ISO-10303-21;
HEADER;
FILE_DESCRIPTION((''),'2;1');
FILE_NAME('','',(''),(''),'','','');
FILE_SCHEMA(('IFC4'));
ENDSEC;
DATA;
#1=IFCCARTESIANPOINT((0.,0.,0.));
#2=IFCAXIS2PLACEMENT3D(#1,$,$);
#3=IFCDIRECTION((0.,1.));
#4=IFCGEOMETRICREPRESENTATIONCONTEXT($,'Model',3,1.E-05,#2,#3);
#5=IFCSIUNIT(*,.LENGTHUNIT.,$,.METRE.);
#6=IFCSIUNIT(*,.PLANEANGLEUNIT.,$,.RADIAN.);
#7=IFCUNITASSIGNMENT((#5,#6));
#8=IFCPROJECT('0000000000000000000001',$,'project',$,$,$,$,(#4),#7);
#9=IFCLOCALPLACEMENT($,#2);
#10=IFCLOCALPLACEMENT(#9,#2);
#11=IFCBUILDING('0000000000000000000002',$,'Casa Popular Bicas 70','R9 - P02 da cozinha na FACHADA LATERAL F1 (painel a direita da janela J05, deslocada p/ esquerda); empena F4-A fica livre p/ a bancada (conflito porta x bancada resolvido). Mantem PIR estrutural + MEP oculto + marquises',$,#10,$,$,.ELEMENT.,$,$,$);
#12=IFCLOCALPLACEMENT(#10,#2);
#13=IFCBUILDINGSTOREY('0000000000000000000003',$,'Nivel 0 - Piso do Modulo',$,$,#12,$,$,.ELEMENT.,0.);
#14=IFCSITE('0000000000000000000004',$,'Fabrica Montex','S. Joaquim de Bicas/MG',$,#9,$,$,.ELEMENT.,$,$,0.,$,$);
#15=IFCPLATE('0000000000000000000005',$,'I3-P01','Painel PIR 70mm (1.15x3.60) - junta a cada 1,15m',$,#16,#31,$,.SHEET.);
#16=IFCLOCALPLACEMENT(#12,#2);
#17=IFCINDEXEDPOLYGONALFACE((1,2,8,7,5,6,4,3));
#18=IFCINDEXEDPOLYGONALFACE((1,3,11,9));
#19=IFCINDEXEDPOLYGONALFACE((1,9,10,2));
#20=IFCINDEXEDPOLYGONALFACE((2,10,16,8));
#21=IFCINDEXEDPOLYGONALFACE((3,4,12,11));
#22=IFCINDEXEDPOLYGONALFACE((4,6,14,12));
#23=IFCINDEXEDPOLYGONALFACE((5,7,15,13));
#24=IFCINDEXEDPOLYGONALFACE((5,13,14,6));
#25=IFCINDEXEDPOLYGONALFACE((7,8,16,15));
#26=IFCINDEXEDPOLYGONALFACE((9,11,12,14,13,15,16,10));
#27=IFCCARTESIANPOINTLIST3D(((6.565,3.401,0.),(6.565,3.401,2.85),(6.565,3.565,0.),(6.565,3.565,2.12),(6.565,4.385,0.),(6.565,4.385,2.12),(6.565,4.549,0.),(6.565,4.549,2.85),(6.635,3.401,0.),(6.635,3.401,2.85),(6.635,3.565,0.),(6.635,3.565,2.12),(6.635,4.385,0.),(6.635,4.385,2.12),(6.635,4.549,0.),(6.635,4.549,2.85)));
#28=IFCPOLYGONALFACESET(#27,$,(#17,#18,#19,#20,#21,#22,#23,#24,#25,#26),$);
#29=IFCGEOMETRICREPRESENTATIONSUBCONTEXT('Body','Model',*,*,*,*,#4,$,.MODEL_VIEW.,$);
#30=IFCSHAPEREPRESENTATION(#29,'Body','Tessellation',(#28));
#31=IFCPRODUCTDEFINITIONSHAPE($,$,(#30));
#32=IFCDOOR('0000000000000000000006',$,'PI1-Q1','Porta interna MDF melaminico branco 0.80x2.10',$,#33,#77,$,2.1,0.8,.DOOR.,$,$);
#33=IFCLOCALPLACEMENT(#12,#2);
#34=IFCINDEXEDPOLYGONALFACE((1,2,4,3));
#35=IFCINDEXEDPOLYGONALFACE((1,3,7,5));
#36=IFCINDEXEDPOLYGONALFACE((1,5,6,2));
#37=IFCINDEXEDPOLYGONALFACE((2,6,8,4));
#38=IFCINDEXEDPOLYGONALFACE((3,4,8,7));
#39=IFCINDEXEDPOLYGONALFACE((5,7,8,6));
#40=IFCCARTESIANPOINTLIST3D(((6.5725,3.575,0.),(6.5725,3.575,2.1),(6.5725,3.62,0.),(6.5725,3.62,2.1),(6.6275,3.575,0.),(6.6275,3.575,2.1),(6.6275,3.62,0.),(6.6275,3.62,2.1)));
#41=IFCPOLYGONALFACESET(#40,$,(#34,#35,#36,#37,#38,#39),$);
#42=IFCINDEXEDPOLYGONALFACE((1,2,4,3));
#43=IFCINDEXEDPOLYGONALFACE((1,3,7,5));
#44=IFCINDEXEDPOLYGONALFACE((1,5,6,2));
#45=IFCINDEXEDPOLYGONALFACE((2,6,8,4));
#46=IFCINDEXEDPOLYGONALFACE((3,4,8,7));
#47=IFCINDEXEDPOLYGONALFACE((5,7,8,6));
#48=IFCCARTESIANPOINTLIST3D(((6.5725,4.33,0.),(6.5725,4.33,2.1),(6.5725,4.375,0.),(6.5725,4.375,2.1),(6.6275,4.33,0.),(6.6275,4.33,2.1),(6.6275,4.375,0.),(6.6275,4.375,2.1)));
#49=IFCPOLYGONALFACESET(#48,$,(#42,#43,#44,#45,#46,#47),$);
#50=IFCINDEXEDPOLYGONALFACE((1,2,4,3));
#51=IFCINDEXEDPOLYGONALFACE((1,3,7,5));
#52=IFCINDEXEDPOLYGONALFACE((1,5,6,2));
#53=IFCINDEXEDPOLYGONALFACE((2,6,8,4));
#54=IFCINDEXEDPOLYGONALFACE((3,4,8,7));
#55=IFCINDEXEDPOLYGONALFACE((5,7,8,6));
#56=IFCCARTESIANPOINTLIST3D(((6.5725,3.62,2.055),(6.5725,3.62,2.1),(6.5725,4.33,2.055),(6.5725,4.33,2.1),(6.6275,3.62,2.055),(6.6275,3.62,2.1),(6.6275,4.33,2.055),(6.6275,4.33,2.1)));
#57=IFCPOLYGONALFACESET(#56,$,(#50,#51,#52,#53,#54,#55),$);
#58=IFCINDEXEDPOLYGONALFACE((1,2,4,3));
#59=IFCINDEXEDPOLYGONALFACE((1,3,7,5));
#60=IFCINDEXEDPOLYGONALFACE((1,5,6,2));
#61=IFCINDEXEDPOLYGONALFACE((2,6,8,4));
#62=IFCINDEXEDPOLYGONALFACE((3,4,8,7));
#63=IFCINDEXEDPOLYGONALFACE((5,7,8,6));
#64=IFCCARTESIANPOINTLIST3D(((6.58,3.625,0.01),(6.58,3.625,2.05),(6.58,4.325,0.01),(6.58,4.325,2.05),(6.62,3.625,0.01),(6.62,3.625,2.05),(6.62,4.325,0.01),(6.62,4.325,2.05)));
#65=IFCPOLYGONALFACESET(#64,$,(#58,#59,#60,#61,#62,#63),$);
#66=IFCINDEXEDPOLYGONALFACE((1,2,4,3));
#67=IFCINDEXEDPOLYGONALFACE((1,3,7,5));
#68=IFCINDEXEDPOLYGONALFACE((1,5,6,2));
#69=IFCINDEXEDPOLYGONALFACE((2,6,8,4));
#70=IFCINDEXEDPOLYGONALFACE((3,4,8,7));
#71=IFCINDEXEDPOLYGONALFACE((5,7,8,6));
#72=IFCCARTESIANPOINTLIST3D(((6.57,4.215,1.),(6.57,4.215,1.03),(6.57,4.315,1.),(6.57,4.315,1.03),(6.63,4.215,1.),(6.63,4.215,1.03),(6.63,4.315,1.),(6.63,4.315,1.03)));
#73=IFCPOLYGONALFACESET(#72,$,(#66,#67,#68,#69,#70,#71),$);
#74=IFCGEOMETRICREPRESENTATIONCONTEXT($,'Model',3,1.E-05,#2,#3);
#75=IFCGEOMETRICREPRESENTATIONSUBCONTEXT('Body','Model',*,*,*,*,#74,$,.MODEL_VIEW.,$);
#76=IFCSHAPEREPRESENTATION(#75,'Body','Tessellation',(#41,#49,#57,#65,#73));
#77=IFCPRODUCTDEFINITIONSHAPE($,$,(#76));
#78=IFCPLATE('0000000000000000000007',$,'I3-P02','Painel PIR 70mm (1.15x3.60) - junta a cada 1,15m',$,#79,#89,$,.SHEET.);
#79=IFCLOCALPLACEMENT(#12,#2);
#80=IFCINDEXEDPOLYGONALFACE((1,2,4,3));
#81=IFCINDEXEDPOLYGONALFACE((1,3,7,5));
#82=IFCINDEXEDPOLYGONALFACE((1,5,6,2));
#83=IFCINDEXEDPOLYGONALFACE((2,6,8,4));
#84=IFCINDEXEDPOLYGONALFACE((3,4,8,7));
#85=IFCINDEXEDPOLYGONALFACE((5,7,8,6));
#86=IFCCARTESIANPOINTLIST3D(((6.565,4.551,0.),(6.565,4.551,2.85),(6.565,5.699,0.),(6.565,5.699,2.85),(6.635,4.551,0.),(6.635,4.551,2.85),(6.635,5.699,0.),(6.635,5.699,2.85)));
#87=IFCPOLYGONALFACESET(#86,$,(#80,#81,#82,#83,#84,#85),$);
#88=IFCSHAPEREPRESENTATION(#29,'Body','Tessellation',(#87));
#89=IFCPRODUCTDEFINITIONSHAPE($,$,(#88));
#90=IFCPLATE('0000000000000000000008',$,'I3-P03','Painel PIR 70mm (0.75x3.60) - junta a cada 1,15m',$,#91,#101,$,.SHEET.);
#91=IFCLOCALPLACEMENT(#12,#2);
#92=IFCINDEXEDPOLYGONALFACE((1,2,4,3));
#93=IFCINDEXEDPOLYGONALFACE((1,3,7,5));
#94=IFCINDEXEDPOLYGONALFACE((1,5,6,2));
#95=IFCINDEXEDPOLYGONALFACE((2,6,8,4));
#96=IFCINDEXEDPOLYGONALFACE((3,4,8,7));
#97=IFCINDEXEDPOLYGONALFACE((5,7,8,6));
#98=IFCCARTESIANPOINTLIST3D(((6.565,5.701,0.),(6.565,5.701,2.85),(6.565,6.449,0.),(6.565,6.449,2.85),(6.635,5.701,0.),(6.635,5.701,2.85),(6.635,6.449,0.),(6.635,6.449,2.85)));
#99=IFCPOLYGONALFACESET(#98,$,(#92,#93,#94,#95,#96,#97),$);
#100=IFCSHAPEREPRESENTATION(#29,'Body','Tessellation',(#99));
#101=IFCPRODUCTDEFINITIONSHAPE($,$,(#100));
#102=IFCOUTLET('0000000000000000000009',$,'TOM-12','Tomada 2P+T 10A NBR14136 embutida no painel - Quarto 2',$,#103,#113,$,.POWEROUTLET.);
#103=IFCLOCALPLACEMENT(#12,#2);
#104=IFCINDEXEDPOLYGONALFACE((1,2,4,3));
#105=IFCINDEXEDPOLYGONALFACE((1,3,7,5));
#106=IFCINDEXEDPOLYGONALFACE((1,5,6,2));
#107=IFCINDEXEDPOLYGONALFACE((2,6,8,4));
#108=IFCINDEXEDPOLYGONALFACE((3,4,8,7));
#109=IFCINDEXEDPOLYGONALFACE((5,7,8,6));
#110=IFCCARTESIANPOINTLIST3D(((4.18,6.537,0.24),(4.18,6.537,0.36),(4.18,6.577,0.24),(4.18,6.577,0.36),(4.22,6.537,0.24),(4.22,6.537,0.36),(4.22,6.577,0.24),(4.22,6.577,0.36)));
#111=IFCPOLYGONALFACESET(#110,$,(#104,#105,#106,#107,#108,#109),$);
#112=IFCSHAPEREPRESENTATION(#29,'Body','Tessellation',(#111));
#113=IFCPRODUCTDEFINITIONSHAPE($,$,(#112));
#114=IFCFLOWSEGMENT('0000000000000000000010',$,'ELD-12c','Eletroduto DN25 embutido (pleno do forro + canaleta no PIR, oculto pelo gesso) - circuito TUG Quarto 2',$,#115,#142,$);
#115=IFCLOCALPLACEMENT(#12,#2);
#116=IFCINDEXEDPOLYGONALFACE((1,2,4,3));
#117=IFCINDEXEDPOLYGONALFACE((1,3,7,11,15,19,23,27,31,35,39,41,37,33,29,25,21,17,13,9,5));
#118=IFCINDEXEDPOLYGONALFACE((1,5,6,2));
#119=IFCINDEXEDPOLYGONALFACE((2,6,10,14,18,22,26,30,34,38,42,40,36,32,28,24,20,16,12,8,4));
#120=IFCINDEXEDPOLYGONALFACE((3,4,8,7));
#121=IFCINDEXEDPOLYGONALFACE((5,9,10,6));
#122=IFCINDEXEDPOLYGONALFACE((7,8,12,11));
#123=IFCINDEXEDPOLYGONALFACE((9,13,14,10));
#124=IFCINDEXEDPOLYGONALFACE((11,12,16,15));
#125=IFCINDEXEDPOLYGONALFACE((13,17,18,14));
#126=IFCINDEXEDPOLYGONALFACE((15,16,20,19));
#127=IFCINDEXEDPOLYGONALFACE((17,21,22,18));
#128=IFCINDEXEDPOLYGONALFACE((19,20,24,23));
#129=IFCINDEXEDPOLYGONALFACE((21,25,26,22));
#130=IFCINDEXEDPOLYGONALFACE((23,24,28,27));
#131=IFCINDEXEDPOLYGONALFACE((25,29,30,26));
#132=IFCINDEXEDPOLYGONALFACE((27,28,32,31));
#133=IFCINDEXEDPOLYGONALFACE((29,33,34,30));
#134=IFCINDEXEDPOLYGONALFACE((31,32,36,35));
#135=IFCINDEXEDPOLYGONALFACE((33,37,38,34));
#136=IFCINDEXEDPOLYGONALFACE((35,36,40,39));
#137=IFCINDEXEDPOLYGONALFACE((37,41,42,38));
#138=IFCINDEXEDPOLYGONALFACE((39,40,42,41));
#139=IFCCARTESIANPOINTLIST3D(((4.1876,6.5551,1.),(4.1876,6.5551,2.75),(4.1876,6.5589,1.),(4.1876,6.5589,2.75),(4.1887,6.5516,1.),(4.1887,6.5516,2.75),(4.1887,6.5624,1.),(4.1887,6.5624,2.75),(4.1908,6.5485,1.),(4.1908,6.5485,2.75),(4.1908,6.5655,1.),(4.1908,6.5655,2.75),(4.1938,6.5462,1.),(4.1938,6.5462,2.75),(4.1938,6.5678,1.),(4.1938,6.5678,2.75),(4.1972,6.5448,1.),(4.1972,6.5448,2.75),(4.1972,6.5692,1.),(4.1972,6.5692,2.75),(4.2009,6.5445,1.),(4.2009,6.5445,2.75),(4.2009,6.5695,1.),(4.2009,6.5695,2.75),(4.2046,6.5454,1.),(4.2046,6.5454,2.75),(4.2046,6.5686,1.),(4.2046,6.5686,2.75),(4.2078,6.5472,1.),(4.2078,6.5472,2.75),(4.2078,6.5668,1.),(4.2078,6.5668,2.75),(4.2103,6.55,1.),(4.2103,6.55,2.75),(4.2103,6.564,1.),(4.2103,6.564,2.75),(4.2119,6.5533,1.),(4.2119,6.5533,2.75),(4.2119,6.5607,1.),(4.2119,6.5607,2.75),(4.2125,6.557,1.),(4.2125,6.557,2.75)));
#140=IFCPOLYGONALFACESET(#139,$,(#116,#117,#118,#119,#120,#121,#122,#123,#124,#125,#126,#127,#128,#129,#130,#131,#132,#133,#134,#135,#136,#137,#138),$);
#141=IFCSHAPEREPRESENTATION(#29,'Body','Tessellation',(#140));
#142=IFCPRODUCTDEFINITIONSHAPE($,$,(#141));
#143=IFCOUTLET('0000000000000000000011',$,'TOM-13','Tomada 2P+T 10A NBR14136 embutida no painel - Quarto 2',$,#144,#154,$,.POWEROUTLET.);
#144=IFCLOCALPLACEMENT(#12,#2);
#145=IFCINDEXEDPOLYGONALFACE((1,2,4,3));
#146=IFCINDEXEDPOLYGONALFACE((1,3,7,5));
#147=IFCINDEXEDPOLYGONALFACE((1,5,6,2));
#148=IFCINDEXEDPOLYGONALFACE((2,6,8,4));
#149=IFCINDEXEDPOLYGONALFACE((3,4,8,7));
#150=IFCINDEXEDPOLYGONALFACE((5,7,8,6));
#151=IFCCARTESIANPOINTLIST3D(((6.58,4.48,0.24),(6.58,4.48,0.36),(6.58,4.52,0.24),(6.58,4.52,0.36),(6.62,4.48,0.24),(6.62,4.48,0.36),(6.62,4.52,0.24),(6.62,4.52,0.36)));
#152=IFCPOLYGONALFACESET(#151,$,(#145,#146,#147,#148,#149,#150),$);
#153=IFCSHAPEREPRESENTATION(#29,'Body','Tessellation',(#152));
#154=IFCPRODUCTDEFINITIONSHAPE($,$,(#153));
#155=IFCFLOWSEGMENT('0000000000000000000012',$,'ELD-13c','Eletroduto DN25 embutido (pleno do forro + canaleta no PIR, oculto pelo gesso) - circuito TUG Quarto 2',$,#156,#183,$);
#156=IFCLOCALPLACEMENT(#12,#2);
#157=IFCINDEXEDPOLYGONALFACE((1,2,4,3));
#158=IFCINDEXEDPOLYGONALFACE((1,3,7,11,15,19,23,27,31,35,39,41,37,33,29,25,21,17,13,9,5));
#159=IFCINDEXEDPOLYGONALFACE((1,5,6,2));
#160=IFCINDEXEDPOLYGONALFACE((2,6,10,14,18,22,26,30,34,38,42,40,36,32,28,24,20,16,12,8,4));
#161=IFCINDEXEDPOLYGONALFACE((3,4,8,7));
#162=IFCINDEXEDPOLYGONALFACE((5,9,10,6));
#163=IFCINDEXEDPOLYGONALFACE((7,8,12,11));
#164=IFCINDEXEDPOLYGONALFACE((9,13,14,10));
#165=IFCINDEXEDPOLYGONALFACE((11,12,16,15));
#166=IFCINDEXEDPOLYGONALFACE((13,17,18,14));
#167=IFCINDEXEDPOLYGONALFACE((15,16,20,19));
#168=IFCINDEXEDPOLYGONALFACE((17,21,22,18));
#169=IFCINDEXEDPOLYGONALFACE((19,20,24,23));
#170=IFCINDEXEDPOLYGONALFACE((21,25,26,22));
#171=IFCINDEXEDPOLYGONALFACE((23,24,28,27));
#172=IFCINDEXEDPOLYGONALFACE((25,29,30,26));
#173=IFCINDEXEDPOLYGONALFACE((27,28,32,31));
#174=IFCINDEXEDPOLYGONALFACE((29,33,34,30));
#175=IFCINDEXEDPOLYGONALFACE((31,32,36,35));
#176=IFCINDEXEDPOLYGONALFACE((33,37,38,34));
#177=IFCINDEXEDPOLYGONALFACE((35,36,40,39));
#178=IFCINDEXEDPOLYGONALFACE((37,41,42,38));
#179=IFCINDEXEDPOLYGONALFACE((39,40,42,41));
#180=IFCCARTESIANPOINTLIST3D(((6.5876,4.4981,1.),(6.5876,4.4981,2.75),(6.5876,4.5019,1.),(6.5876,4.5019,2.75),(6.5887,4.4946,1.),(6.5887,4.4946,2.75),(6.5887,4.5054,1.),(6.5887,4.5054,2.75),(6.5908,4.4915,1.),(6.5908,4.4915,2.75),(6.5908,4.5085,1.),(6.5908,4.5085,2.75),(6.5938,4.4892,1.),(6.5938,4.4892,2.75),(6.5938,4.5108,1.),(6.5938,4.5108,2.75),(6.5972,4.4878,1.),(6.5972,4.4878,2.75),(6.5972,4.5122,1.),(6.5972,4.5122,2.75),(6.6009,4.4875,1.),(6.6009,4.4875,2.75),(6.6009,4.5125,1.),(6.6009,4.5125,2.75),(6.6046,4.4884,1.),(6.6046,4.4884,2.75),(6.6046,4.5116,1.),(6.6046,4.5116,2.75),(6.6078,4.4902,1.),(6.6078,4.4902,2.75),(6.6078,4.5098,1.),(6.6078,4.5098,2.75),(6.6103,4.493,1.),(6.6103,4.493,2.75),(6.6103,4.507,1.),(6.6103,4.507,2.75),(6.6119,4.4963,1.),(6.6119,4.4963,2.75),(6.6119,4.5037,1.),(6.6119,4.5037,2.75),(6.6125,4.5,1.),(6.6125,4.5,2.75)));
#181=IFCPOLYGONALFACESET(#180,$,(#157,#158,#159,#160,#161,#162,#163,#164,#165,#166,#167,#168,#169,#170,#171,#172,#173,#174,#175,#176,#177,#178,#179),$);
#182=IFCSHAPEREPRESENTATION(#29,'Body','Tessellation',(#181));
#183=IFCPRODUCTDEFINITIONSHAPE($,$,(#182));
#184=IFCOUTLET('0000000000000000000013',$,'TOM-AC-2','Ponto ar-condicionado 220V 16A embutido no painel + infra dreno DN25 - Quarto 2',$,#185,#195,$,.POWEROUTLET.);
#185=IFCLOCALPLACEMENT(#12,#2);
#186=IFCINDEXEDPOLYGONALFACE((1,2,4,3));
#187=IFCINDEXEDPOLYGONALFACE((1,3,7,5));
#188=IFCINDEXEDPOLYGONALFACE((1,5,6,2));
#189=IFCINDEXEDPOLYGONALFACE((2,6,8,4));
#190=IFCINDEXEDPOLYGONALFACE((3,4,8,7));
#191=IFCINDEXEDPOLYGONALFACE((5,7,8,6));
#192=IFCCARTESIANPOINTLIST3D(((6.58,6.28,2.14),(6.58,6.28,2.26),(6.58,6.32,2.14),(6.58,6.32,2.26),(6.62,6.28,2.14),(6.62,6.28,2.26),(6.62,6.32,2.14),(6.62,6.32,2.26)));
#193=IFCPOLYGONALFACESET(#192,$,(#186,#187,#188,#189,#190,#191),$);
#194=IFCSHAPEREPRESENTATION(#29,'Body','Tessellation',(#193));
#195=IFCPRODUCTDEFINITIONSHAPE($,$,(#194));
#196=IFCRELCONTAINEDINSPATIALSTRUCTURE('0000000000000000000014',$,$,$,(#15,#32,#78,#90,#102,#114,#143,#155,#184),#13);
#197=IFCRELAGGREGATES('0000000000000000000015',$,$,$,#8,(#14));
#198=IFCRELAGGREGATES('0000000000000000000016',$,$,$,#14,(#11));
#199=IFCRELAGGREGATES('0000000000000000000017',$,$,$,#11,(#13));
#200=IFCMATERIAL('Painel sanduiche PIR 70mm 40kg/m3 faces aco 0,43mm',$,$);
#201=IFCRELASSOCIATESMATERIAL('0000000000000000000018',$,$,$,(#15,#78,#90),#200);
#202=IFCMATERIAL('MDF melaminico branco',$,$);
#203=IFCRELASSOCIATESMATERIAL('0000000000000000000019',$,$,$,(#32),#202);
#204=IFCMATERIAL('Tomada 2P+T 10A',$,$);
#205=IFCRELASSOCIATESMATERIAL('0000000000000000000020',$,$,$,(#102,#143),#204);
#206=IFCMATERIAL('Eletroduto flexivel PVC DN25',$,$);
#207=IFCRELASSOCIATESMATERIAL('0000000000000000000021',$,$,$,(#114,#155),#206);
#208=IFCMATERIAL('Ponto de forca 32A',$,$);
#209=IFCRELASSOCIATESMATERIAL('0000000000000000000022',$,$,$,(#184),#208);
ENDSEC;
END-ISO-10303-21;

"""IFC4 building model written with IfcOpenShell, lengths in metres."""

from ifc_helpers import new_model, si_unit, direction, frame, frame_2d, origin, origin_2d, place, context, subcontext, project, spatial, rectangle, circle, extrude, material, element, fill, save


model = new_model("IFC4")

# Units and contexts
model_context_1 = context("Model", 3, precision=1e-05, world=origin(), true_north=direction((0.0, 1.0)))
model_context_2 = context("Model", 3, precision=1e-05, world=origin(), true_north=direction((0.0, 1.0)))
model_context_3 = context("Model", 3, precision=1e-05, world=origin(), true_north=direction((0.0, 1.0)))
body_context_1 = subcontext(model_context_1, "Body", "Model", "MODEL_VIEW")
body_context_2 = subcontext(model_context_2, "Body", "Model", "MODEL_VIEW")
body_context_3 = subcontext(model_context_3, "Body", "Model", "MODEL_VIEW")
ifc_project = project(units=[si_unit("LENGTHUNIT", "METRE"), si_unit("PLANEANGLEUNIT", "RADIAN")], contexts=[model_context_1])

# Site, building, storey
site_placement = place(None, origin())
site = spatial("IfcSite", under=ifc_project, at=site_placement, Name="Fabrica Montex", Description="S. Joaquim de Bicas/MG", CompositionType="ELEMENT", RefElevation=0.0)
building_placement = place(site_placement, origin())
building = spatial("IfcBuilding", under=site, at=building_placement, Name="Casa Popular Bicas 70", Description="R9 - P02 da cozinha na FACHADA LATERAL F1 (painel a direita da janela J05, deslocada p/ esquerda); empena F4-A fica livre p/ a bancada (conflito porta x bancada resolvido). Mantem PIR estrutural + MEP oculto + marquises", CompositionType="ELEMENT")
storey_placement = place(building_placement, origin())
storey = spatial("IfcBuildingStorey", under=building, at=storey_placement, Name="Nivel 0 - Piso do Modulo", CompositionType="ELEMENT", Elevation=0.0)

# Shared definitions
ifc_material_1 = material(Name="Painel sanduiche PIR 70mm 40kg/m3 faces aco 0,43mm")

# Plate, opening, door
plate_1_placement = place(storey_placement, frame((6.6, 3.401, 0.0), x_axis=(0.0, 1.0, 0.0)))
plate_1 = element("IfcPlate", 1, at=plate_1_placement, inside=storey, material=ifc_material_1, Name="I3-P01", Description="Painel PIR 70mm (1.15x3.60) - junta a cada 1,15m", PredefinedType="SHEET", context=body_context_1, shape_type="SweptSolid", body=[
    extrude(rectangle(XDim=1.148, YDim=0.07, at=frame_2d((0.574, 0.0))), origin(), (0.0, 0.0, 1.0), 2.85),
])
placement_1 = place(None, origin())
placement_2 = place(placement_1, origin())
placement_3 = place(placement_2, origin())
opening_1_placement = place(placement_3, frame((6.6, 3.575, 0.0), x_axis=(0.0, 1.0, 0.0)))
opening_1 = element("IfcOpeningElement", 2, at=opening_1_placement, cuts=plate_1, PredefinedType="OPENING", context=body_context_3, shape_type="SweptSolid", body=[
    extrude(rectangle(XDim=0.82, YDim=0.3, at=frame_2d((0.4, 0.0))), origin(), (0.0, 0.0, 1.0), 2.12),
])
ifc_material_2 = material(Name="MDF melaminico branco")
placement_4 = place(None, origin())
placement_5 = place(placement_4, origin())
placement_6 = place(placement_5, origin())
door_placement = place(placement_6, frame((6.6, 3.575, 0.0), x_axis=(0.0, 1.0, 0.0)))
door = element("IfcDoor", 3, at=door_placement, inside=storey, material=ifc_material_2, Name="PI1-Q1", Description="Porta interna MDF melaminico branco 0.80x2.10", OverallHeight=2.1, OverallWidth=0.8, PredefinedType="DOOR", context=body_context_2, shape_type="SweptSolid", body=[
    extrude(rectangle(XDim=0.045, YDim=0.055, at=frame_2d((0.0225, 0.0))), origin(), (0.0, 0.0, 1.0), 2.1),
    extrude(rectangle(XDim=0.045, YDim=0.055, at=frame_2d((0.7775, 0.0))), origin(), (0.0, 0.0, 1.0), 2.1),
    extrude(rectangle(XDim=0.71, YDim=0.055, at=frame_2d((0.4, 0.0))), frame((0.0, 0.0, 2.055)), (0.0, 0.0, 1.0), 0.045),
    extrude(rectangle(XDim=0.7, YDim=0.04, at=frame_2d((0.4, 0.0))), frame((0.0, 0.0, 0.01)), (0.0, 0.0, 1.0), 2.04),
    extrude(rectangle(XDim=0.1, YDim=0.06, at=frame_2d((0.69, 0.0))), frame((0.0, 0.0, 1.0)), (0.0, 0.0, 1.0), 0.03),
])
fill(opening_1, door)

# Plates
plate_2_placement = place(storey_placement, frame((6.6, 4.551, 0.0), x_axis=(0.0, 1.0, 0.0)))
element("IfcPlate", 4, at=plate_2_placement, inside=storey, material=ifc_material_1, Name="I3-P02", Description="Painel PIR 70mm (1.15x3.60) - junta a cada 1,15m", PredefinedType="SHEET", context=body_context_1, shape_type="SweptSolid", body=[
    extrude(rectangle(XDim=1.148, YDim=0.07, at=frame_2d((0.574, 0.0))), origin(), (0.0, 0.0, 1.0), 2.85),
])
plate_3_placement = place(storey_placement, frame((6.6, 5.701, 0.0), x_axis=(0.0, 1.0, 0.0)))
element("IfcPlate", 5, at=plate_3_placement, inside=storey, material=ifc_material_1, Name="I3-P03", Description="Painel PIR 70mm (0.75x3.60) - junta a cada 1,15m", PredefinedType="SHEET", context=body_context_1, shape_type="SweptSolid", body=[
    extrude(rectangle(XDim=0.748, YDim=0.07, at=frame_2d((0.374, 0.0))), origin(), (0.0, 0.0, 1.0), 2.85),
])

# Outlet
ifc_material_3 = material(Name="Tomada 2P+T 10A")
outlet_1_placement = place(storey_placement, frame((4.18, 6.537, 0.24)))
element("IfcOutlet", 6, at=outlet_1_placement, inside=storey, material=ifc_material_3, Name="TOM-12", Description="Tomada 2P+T 10A NBR14136 embutida no painel - Quarto 2", PredefinedType="POWEROUTLET", context=body_context_1, shape_type="SweptSolid", body=[
    extrude(rectangle(XDim=0.04, YDim=0.04, at=frame_2d((0.02, 0.02))), origin(), (0.0, 0.0, 1.0), 0.12),
])

# Flow segment
ifc_material_4 = material(Name="Eletroduto flexivel PVC DN25")
flow_segment_1_placement = place(storey_placement, frame((4.2, 6.557, 2.75), z_axis=(0.0, 0.0, -1.0), x_axis=(1.0, 0.0, 0.0)))
element("IfcFlowSegment", 7, at=flow_segment_1_placement, inside=storey, material=ifc_material_4, Name="ELD-12c", Description="Eletroduto DN25 embutido (pleno do forro + canaleta no PIR, oculto pelo gesso) - circuito TUG Quarto 2", context=body_context_1, shape_type="SweptSolid", body=[
    extrude(circle(Radius=0.0125, at=origin_2d()), origin(), (0.0, 0.0, 1.0), 1.75),
])

# Outlet
outlet_2_placement = place(storey_placement, frame((6.58, 4.48, 0.24)))
element("IfcOutlet", 8, at=outlet_2_placement, inside=storey, material=ifc_material_3, Name="TOM-13", Description="Tomada 2P+T 10A NBR14136 embutida no painel - Quarto 2", PredefinedType="POWEROUTLET", context=body_context_1, shape_type="SweptSolid", body=[
    extrude(rectangle(XDim=0.04, YDim=0.04, at=frame_2d((0.02, 0.02))), origin(), (0.0, 0.0, 1.0), 0.12),
])

# Flow segment
flow_segment_2_placement = place(storey_placement, frame((6.6, 4.5, 2.75), z_axis=(0.0, 0.0, -1.0), x_axis=(1.0, 0.0, 0.0)))
element("IfcFlowSegment", 9, at=flow_segment_2_placement, inside=storey, material=ifc_material_4, Name="ELD-13c", Description="Eletroduto DN25 embutido (pleno do forro + canaleta no PIR, oculto pelo gesso) - circuito TUG Quarto 2", context=body_context_1, shape_type="SweptSolid", body=[
    extrude(circle(Radius=0.0125, at=origin_2d()), origin(), (0.0, 0.0, 1.0), 1.75),
])

# Outlet
ifc_material_5 = material(Name="Ponto de forca 32A")
outlet_3_placement = place(storey_placement, frame((6.58, 6.28, 2.14)))
element("IfcOutlet", 10, at=outlet_3_placement, inside=storey, material=ifc_material_5, Name="TOM-AC-2", Description="Ponto ar-condicionado 220V 16A embutido no painel + infra dreno DN25 - Quarto 2", PredefinedType="POWEROUTLET", context=body_context_1, shape_type="SweptSolid", body=[
    extrude(rectangle(XDim=0.04, YDim=0.04, at=frame_2d((0.02, 0.02))), origin(), (0.0, 0.0, 1.0), 0.12),
])

save(model, "model.ifc")
